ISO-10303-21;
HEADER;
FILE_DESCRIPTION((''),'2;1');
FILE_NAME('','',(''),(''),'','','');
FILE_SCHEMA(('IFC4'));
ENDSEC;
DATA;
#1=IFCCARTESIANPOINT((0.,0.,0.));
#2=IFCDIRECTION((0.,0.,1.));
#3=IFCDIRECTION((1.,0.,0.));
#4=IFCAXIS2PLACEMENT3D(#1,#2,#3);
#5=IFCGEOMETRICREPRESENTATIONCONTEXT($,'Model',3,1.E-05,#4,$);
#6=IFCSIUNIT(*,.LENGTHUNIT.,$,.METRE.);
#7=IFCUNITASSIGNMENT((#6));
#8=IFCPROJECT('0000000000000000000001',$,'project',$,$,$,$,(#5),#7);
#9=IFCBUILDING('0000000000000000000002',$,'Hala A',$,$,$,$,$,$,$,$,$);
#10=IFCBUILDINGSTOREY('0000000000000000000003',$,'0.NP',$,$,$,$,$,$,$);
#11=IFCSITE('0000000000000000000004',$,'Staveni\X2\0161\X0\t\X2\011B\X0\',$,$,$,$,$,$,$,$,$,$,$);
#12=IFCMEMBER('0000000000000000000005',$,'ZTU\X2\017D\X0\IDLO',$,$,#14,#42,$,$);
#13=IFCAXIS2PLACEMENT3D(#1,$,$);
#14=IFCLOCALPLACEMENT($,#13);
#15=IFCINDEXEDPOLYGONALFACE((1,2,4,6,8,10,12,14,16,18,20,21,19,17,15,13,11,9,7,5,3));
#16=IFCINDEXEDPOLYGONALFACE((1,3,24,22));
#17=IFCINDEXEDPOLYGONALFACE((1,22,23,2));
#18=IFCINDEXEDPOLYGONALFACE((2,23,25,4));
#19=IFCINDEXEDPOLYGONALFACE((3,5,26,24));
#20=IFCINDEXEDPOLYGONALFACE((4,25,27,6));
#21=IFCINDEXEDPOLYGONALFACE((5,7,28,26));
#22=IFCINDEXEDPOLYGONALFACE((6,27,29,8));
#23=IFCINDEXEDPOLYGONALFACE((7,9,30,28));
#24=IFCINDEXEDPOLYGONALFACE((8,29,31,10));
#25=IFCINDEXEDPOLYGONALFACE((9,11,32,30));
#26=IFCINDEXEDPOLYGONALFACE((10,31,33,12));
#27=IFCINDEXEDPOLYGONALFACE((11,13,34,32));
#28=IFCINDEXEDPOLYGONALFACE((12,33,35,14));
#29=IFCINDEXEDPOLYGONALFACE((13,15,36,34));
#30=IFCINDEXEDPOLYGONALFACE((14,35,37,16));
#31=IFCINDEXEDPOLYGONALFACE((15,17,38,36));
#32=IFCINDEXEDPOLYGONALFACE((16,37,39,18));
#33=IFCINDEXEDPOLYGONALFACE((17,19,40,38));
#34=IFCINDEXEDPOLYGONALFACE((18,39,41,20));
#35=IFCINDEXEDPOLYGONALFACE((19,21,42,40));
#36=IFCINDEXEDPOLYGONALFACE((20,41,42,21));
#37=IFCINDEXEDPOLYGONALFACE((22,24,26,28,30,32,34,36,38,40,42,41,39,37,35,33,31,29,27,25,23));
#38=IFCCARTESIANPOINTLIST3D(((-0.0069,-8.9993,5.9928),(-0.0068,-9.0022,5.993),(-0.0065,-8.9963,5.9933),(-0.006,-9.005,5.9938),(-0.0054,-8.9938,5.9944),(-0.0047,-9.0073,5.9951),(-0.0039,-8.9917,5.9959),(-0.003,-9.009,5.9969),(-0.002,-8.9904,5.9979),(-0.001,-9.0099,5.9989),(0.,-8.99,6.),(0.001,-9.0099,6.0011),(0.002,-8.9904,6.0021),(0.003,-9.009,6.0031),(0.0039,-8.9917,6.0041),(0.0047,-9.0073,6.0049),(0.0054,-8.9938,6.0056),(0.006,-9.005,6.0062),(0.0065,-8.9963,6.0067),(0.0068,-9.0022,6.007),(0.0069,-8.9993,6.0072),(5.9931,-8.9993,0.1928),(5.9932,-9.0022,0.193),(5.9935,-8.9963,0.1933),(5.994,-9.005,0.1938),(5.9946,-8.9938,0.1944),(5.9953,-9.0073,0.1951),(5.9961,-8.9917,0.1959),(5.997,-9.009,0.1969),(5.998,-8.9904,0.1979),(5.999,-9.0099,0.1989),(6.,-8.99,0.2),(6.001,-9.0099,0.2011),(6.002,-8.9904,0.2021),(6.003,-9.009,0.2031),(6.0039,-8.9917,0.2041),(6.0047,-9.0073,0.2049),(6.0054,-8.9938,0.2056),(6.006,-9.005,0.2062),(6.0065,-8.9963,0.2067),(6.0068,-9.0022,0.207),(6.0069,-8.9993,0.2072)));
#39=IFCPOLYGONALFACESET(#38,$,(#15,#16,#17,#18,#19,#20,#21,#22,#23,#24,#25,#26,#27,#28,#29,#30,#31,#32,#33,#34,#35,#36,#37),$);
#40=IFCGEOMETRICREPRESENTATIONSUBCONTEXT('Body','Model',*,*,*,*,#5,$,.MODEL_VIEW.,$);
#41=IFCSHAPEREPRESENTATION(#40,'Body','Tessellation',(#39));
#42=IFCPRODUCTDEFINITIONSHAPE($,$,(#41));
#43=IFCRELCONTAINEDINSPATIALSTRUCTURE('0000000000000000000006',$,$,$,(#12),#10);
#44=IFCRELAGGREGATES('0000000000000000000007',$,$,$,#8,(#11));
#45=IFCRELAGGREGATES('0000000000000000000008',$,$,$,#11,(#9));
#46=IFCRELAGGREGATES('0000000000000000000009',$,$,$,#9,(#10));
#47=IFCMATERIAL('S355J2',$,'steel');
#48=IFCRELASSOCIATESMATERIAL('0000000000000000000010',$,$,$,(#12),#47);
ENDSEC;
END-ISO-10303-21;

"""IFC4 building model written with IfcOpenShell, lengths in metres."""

from ifc_helpers import new_model, si_unit, frame, origin_with_axes, place, context, subcontext, project, spatial, circle, extrude, material, element, save


model = new_model("IFC4")

# Units and contexts
model_context = context("Model", 3, precision=1e-05, world=origin_with_axes())
body_context = subcontext(model_context, "Body", "Model", "MODEL_VIEW")
ifc_project = project(units=[si_unit("LENGTHUNIT", "METRE")], contexts=[model_context])

# Site, building, storey
site = spatial("IfcSite", under=ifc_project, Name="Staveniště")
building = spatial("IfcBuilding", under=site, Name="Hala A")
storey = spatial("IfcBuildingStorey", under=building, Name="0.NP")

# Shared definitions
ifc_material = material(Name="S355J2", Category="steel")

# Member
for number, where, z_axis, x_axis, name in (
    (1, (0.0, -9.0, 6.0), (0.718988, 0.0, -0.695022), (0.0, 1.0, 0.0), "ZTUŽIDLO"),
):
    element("IfcMember", number, at=place(None, frame(where, z_axis=z_axis, x_axis=x_axis)), inside=storey, material=ifc_material, Name=name, context=body_context, shape_type="SweptSolid", body=[
        extrude(circle(Radius=0.01), origin_with_axes(), (0.0, 0.0, 1.0), 8.3451),
    ])

save(model, "model.ifc")
